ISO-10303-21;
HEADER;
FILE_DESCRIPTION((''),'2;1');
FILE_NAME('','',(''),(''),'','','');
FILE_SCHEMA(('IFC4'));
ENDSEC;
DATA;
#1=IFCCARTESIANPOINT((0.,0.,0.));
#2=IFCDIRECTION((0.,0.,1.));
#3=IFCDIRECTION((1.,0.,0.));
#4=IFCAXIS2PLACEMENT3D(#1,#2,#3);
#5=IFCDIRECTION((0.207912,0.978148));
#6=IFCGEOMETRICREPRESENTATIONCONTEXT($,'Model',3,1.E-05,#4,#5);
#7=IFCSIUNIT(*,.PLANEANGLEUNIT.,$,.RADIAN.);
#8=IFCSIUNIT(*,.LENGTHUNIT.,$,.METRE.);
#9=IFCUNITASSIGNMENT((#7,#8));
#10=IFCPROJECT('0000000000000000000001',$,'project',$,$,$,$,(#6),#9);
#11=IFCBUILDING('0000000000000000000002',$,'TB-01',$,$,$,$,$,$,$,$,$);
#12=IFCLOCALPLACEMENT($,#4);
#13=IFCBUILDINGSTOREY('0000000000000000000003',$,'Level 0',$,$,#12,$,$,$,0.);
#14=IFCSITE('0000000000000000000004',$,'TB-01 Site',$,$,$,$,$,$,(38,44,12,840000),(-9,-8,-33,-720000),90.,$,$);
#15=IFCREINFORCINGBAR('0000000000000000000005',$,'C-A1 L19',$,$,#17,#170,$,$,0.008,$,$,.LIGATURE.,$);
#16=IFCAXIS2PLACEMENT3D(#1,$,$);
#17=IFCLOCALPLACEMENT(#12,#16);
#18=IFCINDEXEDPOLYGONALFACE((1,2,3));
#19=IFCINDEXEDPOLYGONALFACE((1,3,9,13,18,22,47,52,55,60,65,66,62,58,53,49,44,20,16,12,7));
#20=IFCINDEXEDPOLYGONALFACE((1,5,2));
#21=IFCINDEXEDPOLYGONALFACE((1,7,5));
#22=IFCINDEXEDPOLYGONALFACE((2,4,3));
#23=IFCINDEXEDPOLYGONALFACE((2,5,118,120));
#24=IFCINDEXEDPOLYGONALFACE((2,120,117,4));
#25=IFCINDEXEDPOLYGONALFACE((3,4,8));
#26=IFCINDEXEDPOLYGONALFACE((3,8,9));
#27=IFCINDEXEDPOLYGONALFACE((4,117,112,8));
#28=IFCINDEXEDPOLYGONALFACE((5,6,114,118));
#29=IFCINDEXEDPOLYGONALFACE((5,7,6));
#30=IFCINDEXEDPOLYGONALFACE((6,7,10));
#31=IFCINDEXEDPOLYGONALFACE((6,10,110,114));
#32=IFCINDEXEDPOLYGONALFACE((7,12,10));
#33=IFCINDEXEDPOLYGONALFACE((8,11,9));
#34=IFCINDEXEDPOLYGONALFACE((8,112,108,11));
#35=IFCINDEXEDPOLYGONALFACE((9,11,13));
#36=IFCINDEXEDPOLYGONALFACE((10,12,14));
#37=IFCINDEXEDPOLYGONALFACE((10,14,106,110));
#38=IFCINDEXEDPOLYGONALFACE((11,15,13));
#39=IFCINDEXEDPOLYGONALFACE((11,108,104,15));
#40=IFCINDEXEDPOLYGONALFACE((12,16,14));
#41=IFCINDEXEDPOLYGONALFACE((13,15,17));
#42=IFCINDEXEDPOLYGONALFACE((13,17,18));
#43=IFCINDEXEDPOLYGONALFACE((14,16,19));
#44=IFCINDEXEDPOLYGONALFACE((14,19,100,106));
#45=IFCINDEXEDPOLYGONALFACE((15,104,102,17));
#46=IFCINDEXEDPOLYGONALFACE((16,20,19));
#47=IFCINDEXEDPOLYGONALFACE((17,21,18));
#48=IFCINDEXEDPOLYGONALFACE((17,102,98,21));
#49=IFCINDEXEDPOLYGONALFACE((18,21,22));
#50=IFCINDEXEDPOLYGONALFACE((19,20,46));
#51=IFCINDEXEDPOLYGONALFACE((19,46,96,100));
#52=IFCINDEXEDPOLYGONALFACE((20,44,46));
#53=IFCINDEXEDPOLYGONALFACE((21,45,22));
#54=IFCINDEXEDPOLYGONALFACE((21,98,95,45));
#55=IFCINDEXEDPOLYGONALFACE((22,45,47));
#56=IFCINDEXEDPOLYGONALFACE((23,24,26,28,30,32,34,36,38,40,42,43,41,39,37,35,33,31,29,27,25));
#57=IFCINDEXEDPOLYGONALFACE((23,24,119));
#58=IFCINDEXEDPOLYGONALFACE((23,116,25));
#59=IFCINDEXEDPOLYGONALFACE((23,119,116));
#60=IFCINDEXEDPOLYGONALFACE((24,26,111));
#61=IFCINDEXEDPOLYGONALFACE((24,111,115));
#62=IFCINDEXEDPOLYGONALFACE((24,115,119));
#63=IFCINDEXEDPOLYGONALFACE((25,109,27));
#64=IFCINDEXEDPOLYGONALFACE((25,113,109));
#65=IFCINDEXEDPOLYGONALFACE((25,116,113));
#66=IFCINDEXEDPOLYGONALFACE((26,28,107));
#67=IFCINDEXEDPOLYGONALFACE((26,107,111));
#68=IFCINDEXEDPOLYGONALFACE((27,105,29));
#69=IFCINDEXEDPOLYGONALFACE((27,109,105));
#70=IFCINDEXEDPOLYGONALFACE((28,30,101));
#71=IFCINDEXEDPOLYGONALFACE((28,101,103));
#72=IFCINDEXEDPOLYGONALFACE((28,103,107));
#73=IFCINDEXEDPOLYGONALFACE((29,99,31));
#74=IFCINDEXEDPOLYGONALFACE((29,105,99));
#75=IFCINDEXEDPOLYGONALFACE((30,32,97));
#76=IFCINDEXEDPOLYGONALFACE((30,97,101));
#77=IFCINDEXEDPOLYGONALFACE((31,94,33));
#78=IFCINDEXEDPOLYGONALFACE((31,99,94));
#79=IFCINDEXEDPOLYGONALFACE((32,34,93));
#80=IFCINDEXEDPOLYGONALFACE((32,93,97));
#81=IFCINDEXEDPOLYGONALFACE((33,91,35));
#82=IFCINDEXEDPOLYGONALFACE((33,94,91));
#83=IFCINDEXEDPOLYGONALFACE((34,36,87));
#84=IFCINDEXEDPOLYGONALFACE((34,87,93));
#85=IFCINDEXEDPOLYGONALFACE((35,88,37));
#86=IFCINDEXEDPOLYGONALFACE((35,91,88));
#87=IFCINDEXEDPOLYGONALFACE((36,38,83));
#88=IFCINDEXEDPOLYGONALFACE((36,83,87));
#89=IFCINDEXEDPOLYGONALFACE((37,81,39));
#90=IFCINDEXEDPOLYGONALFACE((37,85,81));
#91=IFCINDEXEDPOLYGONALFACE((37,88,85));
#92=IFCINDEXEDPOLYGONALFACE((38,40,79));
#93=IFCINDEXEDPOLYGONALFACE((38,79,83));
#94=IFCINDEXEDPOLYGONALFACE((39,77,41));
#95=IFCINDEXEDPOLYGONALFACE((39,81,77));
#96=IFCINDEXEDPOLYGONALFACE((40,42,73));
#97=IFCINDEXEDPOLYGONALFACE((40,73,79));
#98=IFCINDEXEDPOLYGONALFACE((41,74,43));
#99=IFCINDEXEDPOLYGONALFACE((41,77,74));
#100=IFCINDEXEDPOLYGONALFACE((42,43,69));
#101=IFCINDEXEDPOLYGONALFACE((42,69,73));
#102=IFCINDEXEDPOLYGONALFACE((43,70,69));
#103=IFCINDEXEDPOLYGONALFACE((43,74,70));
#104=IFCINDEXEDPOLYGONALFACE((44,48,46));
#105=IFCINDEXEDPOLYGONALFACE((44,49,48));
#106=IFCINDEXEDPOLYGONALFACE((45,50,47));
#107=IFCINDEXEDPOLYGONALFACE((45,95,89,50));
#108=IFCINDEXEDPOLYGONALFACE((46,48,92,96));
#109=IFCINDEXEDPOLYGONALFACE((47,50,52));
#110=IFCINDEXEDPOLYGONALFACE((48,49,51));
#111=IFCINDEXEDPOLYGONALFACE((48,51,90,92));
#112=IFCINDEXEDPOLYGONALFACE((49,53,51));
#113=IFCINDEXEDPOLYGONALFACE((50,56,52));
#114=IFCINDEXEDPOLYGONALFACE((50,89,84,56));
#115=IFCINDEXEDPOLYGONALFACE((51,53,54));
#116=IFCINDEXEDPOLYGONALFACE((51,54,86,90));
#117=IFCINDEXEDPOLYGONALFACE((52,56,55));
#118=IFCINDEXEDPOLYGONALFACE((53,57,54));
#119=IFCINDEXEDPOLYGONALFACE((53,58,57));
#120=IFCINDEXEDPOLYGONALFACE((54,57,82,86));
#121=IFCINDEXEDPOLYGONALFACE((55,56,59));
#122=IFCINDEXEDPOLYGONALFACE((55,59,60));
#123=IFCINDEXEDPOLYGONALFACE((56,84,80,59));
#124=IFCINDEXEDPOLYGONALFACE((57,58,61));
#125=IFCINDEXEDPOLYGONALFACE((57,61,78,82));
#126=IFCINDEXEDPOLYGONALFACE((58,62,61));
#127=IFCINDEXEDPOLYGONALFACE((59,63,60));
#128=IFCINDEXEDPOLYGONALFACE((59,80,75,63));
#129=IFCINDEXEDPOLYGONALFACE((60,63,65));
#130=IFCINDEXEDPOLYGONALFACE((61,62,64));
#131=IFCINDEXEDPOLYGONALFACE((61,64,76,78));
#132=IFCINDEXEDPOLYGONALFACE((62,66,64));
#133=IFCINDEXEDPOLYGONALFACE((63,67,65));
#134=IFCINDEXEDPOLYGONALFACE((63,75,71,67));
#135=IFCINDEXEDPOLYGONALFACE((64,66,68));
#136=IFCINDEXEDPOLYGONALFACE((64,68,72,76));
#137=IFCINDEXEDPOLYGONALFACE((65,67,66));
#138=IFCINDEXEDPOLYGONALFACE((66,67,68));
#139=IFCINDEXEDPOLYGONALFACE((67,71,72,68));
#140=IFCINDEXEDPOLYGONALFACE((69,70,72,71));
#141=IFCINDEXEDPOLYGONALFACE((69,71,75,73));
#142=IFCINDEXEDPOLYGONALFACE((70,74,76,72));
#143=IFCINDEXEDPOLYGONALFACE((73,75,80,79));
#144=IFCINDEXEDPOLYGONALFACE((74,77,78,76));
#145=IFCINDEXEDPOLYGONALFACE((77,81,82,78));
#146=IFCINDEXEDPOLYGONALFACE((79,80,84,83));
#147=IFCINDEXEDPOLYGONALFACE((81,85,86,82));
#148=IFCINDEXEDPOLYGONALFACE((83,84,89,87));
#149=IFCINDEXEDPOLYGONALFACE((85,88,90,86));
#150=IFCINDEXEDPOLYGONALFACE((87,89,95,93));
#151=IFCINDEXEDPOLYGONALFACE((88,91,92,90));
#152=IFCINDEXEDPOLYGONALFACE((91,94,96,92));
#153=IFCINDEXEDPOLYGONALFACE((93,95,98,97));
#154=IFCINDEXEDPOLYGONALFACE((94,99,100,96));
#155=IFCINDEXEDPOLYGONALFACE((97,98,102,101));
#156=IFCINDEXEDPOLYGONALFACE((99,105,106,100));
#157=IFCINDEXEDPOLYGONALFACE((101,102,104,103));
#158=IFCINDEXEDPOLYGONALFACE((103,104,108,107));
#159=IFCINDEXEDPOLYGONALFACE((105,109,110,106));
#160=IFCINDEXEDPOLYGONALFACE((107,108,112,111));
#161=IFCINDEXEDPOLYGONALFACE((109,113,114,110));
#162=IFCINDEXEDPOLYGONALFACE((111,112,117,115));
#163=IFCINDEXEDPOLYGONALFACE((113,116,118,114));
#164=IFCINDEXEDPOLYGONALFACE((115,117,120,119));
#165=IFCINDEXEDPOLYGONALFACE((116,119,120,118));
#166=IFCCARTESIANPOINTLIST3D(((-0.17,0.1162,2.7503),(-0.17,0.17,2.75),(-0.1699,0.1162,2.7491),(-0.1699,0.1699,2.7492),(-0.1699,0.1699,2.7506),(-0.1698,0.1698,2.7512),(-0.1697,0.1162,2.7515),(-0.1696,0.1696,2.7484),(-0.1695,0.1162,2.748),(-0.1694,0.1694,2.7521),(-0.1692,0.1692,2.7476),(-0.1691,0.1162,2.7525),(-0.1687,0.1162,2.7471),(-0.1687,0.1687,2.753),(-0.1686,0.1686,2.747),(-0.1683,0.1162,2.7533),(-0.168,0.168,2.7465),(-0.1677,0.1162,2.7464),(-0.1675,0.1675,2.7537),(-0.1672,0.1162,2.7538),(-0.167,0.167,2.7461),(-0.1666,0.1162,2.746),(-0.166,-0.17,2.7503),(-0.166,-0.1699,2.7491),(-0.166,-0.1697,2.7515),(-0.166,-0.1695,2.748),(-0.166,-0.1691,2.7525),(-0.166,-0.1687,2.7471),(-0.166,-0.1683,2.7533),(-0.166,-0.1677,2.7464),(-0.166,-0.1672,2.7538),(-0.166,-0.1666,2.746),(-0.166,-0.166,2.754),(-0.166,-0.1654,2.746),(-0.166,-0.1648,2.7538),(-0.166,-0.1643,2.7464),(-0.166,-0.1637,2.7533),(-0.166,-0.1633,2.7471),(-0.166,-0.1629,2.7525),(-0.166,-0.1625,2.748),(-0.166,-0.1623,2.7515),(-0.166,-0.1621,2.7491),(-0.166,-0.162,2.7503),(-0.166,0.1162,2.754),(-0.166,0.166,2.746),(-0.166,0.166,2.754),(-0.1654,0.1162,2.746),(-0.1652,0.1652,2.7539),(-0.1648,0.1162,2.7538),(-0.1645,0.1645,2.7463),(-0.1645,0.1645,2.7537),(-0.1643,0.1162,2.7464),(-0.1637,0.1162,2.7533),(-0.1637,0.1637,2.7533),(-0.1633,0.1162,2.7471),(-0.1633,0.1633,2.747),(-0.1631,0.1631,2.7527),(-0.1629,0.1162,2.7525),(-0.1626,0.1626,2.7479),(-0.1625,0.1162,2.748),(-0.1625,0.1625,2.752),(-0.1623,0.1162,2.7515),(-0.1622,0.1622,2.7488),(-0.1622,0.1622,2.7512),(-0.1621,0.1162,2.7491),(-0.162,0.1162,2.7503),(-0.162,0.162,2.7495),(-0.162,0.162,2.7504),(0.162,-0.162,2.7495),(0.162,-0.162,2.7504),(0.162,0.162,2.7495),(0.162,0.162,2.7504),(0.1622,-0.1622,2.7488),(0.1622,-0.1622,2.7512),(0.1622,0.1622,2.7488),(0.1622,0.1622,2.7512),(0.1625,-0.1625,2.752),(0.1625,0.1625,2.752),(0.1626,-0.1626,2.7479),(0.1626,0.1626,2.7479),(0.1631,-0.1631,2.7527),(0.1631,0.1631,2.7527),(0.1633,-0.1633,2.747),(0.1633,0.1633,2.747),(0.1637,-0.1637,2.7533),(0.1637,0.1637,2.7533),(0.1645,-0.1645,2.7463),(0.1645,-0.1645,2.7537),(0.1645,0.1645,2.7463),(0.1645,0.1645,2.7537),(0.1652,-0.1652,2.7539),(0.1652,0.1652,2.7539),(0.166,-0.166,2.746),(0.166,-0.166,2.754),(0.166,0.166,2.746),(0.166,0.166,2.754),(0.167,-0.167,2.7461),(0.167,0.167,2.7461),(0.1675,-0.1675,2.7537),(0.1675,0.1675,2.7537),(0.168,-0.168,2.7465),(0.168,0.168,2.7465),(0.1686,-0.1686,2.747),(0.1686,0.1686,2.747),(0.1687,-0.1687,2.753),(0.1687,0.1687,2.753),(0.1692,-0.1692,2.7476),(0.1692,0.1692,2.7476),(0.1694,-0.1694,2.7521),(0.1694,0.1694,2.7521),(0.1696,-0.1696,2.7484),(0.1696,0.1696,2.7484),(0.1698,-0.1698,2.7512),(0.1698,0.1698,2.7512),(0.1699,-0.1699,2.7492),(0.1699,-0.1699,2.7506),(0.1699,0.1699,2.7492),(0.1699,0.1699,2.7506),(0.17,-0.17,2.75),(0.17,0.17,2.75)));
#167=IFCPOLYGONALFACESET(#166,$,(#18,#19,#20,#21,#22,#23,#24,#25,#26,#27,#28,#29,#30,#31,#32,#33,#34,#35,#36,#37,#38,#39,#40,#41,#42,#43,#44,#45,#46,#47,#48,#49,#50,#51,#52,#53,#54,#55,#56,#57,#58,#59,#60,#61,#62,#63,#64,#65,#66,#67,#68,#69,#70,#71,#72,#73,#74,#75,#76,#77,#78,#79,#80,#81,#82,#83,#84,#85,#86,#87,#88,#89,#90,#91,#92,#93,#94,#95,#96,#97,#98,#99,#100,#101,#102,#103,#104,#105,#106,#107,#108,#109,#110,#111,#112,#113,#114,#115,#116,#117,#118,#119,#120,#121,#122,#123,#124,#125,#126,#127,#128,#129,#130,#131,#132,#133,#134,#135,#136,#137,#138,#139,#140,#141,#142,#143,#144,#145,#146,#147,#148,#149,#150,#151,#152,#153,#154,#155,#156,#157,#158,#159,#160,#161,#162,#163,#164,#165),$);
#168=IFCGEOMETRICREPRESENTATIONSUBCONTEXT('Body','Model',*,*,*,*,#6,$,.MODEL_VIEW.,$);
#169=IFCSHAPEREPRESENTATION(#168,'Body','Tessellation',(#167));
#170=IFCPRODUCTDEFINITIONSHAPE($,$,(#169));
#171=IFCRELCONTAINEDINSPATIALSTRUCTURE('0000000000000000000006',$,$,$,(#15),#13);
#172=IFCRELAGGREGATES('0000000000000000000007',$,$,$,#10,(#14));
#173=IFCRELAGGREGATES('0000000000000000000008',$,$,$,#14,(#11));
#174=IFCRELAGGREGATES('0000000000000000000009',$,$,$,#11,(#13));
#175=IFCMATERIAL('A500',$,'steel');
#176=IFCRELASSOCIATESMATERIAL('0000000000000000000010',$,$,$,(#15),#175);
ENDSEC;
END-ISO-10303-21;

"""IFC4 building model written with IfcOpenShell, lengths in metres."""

from ifc_helpers import new_model, entity, si_unit, direction, origin_with_axes, place, context, subcontext, project, spatial, material, element, save


model = new_model("IFC4")

# Units and contexts
model_context = context("Model", 3, precision=1e-05, world=origin_with_axes(), true_north=direction((0.207912, 0.978148)))
body_context = subcontext(model_context, "Body", "Model", "MODEL_VIEW")
ifc_project = project(units=[si_unit("PLANEANGLEUNIT", "RADIAN"), si_unit("LENGTHUNIT", "METRE")], contexts=[model_context])

# Site, building, storey
site = spatial("IfcSite", under=ifc_project, Name="TB-01 Site", RefLatitude=(38, 44, 12, 840000), RefLongitude=(-9, -8, -33, -720000), RefElevation=90.0)
building = spatial("IfcBuilding", under=site, Name="TB-01")
storey_placement = place(None, origin_with_axes())
storey = spatial("IfcBuildingStorey", under=building, at=storey_placement, Name="Level 0", Elevation=0.0)

# Reinforcing bar
ifc_material_1 = material(Name="A500", Category="steel")
reinforcing_bar_1_placement = place(storey_placement, origin_with_axes())
element("IfcReinforcingBar", 1, at=reinforcing_bar_1_placement, inside=storey, material=ifc_material_1, Name="C-A1 L19", NominalDiameter=0.008, PredefinedType="LIGATURE", context=body_context, shape_type="AdvancedSweptSolid", body=[
    entity("IfcSweptDiskSolid", entity("IfcPolyline", [entity("IfcCartesianPoint", [-0.166, -0.166, 2.75]), entity("IfcCartesianPoint", [0.166, -0.166, 2.75]), entity("IfcCartesianPoint", [0.166, 0.166, 2.75]), entity("IfcCartesianPoint", [-0.166, 0.166, 2.75]), entity("IfcCartesianPoint", [-0.166, 0.1162, 2.75])]), 0.004),
])

save(model, "model.ifc")
